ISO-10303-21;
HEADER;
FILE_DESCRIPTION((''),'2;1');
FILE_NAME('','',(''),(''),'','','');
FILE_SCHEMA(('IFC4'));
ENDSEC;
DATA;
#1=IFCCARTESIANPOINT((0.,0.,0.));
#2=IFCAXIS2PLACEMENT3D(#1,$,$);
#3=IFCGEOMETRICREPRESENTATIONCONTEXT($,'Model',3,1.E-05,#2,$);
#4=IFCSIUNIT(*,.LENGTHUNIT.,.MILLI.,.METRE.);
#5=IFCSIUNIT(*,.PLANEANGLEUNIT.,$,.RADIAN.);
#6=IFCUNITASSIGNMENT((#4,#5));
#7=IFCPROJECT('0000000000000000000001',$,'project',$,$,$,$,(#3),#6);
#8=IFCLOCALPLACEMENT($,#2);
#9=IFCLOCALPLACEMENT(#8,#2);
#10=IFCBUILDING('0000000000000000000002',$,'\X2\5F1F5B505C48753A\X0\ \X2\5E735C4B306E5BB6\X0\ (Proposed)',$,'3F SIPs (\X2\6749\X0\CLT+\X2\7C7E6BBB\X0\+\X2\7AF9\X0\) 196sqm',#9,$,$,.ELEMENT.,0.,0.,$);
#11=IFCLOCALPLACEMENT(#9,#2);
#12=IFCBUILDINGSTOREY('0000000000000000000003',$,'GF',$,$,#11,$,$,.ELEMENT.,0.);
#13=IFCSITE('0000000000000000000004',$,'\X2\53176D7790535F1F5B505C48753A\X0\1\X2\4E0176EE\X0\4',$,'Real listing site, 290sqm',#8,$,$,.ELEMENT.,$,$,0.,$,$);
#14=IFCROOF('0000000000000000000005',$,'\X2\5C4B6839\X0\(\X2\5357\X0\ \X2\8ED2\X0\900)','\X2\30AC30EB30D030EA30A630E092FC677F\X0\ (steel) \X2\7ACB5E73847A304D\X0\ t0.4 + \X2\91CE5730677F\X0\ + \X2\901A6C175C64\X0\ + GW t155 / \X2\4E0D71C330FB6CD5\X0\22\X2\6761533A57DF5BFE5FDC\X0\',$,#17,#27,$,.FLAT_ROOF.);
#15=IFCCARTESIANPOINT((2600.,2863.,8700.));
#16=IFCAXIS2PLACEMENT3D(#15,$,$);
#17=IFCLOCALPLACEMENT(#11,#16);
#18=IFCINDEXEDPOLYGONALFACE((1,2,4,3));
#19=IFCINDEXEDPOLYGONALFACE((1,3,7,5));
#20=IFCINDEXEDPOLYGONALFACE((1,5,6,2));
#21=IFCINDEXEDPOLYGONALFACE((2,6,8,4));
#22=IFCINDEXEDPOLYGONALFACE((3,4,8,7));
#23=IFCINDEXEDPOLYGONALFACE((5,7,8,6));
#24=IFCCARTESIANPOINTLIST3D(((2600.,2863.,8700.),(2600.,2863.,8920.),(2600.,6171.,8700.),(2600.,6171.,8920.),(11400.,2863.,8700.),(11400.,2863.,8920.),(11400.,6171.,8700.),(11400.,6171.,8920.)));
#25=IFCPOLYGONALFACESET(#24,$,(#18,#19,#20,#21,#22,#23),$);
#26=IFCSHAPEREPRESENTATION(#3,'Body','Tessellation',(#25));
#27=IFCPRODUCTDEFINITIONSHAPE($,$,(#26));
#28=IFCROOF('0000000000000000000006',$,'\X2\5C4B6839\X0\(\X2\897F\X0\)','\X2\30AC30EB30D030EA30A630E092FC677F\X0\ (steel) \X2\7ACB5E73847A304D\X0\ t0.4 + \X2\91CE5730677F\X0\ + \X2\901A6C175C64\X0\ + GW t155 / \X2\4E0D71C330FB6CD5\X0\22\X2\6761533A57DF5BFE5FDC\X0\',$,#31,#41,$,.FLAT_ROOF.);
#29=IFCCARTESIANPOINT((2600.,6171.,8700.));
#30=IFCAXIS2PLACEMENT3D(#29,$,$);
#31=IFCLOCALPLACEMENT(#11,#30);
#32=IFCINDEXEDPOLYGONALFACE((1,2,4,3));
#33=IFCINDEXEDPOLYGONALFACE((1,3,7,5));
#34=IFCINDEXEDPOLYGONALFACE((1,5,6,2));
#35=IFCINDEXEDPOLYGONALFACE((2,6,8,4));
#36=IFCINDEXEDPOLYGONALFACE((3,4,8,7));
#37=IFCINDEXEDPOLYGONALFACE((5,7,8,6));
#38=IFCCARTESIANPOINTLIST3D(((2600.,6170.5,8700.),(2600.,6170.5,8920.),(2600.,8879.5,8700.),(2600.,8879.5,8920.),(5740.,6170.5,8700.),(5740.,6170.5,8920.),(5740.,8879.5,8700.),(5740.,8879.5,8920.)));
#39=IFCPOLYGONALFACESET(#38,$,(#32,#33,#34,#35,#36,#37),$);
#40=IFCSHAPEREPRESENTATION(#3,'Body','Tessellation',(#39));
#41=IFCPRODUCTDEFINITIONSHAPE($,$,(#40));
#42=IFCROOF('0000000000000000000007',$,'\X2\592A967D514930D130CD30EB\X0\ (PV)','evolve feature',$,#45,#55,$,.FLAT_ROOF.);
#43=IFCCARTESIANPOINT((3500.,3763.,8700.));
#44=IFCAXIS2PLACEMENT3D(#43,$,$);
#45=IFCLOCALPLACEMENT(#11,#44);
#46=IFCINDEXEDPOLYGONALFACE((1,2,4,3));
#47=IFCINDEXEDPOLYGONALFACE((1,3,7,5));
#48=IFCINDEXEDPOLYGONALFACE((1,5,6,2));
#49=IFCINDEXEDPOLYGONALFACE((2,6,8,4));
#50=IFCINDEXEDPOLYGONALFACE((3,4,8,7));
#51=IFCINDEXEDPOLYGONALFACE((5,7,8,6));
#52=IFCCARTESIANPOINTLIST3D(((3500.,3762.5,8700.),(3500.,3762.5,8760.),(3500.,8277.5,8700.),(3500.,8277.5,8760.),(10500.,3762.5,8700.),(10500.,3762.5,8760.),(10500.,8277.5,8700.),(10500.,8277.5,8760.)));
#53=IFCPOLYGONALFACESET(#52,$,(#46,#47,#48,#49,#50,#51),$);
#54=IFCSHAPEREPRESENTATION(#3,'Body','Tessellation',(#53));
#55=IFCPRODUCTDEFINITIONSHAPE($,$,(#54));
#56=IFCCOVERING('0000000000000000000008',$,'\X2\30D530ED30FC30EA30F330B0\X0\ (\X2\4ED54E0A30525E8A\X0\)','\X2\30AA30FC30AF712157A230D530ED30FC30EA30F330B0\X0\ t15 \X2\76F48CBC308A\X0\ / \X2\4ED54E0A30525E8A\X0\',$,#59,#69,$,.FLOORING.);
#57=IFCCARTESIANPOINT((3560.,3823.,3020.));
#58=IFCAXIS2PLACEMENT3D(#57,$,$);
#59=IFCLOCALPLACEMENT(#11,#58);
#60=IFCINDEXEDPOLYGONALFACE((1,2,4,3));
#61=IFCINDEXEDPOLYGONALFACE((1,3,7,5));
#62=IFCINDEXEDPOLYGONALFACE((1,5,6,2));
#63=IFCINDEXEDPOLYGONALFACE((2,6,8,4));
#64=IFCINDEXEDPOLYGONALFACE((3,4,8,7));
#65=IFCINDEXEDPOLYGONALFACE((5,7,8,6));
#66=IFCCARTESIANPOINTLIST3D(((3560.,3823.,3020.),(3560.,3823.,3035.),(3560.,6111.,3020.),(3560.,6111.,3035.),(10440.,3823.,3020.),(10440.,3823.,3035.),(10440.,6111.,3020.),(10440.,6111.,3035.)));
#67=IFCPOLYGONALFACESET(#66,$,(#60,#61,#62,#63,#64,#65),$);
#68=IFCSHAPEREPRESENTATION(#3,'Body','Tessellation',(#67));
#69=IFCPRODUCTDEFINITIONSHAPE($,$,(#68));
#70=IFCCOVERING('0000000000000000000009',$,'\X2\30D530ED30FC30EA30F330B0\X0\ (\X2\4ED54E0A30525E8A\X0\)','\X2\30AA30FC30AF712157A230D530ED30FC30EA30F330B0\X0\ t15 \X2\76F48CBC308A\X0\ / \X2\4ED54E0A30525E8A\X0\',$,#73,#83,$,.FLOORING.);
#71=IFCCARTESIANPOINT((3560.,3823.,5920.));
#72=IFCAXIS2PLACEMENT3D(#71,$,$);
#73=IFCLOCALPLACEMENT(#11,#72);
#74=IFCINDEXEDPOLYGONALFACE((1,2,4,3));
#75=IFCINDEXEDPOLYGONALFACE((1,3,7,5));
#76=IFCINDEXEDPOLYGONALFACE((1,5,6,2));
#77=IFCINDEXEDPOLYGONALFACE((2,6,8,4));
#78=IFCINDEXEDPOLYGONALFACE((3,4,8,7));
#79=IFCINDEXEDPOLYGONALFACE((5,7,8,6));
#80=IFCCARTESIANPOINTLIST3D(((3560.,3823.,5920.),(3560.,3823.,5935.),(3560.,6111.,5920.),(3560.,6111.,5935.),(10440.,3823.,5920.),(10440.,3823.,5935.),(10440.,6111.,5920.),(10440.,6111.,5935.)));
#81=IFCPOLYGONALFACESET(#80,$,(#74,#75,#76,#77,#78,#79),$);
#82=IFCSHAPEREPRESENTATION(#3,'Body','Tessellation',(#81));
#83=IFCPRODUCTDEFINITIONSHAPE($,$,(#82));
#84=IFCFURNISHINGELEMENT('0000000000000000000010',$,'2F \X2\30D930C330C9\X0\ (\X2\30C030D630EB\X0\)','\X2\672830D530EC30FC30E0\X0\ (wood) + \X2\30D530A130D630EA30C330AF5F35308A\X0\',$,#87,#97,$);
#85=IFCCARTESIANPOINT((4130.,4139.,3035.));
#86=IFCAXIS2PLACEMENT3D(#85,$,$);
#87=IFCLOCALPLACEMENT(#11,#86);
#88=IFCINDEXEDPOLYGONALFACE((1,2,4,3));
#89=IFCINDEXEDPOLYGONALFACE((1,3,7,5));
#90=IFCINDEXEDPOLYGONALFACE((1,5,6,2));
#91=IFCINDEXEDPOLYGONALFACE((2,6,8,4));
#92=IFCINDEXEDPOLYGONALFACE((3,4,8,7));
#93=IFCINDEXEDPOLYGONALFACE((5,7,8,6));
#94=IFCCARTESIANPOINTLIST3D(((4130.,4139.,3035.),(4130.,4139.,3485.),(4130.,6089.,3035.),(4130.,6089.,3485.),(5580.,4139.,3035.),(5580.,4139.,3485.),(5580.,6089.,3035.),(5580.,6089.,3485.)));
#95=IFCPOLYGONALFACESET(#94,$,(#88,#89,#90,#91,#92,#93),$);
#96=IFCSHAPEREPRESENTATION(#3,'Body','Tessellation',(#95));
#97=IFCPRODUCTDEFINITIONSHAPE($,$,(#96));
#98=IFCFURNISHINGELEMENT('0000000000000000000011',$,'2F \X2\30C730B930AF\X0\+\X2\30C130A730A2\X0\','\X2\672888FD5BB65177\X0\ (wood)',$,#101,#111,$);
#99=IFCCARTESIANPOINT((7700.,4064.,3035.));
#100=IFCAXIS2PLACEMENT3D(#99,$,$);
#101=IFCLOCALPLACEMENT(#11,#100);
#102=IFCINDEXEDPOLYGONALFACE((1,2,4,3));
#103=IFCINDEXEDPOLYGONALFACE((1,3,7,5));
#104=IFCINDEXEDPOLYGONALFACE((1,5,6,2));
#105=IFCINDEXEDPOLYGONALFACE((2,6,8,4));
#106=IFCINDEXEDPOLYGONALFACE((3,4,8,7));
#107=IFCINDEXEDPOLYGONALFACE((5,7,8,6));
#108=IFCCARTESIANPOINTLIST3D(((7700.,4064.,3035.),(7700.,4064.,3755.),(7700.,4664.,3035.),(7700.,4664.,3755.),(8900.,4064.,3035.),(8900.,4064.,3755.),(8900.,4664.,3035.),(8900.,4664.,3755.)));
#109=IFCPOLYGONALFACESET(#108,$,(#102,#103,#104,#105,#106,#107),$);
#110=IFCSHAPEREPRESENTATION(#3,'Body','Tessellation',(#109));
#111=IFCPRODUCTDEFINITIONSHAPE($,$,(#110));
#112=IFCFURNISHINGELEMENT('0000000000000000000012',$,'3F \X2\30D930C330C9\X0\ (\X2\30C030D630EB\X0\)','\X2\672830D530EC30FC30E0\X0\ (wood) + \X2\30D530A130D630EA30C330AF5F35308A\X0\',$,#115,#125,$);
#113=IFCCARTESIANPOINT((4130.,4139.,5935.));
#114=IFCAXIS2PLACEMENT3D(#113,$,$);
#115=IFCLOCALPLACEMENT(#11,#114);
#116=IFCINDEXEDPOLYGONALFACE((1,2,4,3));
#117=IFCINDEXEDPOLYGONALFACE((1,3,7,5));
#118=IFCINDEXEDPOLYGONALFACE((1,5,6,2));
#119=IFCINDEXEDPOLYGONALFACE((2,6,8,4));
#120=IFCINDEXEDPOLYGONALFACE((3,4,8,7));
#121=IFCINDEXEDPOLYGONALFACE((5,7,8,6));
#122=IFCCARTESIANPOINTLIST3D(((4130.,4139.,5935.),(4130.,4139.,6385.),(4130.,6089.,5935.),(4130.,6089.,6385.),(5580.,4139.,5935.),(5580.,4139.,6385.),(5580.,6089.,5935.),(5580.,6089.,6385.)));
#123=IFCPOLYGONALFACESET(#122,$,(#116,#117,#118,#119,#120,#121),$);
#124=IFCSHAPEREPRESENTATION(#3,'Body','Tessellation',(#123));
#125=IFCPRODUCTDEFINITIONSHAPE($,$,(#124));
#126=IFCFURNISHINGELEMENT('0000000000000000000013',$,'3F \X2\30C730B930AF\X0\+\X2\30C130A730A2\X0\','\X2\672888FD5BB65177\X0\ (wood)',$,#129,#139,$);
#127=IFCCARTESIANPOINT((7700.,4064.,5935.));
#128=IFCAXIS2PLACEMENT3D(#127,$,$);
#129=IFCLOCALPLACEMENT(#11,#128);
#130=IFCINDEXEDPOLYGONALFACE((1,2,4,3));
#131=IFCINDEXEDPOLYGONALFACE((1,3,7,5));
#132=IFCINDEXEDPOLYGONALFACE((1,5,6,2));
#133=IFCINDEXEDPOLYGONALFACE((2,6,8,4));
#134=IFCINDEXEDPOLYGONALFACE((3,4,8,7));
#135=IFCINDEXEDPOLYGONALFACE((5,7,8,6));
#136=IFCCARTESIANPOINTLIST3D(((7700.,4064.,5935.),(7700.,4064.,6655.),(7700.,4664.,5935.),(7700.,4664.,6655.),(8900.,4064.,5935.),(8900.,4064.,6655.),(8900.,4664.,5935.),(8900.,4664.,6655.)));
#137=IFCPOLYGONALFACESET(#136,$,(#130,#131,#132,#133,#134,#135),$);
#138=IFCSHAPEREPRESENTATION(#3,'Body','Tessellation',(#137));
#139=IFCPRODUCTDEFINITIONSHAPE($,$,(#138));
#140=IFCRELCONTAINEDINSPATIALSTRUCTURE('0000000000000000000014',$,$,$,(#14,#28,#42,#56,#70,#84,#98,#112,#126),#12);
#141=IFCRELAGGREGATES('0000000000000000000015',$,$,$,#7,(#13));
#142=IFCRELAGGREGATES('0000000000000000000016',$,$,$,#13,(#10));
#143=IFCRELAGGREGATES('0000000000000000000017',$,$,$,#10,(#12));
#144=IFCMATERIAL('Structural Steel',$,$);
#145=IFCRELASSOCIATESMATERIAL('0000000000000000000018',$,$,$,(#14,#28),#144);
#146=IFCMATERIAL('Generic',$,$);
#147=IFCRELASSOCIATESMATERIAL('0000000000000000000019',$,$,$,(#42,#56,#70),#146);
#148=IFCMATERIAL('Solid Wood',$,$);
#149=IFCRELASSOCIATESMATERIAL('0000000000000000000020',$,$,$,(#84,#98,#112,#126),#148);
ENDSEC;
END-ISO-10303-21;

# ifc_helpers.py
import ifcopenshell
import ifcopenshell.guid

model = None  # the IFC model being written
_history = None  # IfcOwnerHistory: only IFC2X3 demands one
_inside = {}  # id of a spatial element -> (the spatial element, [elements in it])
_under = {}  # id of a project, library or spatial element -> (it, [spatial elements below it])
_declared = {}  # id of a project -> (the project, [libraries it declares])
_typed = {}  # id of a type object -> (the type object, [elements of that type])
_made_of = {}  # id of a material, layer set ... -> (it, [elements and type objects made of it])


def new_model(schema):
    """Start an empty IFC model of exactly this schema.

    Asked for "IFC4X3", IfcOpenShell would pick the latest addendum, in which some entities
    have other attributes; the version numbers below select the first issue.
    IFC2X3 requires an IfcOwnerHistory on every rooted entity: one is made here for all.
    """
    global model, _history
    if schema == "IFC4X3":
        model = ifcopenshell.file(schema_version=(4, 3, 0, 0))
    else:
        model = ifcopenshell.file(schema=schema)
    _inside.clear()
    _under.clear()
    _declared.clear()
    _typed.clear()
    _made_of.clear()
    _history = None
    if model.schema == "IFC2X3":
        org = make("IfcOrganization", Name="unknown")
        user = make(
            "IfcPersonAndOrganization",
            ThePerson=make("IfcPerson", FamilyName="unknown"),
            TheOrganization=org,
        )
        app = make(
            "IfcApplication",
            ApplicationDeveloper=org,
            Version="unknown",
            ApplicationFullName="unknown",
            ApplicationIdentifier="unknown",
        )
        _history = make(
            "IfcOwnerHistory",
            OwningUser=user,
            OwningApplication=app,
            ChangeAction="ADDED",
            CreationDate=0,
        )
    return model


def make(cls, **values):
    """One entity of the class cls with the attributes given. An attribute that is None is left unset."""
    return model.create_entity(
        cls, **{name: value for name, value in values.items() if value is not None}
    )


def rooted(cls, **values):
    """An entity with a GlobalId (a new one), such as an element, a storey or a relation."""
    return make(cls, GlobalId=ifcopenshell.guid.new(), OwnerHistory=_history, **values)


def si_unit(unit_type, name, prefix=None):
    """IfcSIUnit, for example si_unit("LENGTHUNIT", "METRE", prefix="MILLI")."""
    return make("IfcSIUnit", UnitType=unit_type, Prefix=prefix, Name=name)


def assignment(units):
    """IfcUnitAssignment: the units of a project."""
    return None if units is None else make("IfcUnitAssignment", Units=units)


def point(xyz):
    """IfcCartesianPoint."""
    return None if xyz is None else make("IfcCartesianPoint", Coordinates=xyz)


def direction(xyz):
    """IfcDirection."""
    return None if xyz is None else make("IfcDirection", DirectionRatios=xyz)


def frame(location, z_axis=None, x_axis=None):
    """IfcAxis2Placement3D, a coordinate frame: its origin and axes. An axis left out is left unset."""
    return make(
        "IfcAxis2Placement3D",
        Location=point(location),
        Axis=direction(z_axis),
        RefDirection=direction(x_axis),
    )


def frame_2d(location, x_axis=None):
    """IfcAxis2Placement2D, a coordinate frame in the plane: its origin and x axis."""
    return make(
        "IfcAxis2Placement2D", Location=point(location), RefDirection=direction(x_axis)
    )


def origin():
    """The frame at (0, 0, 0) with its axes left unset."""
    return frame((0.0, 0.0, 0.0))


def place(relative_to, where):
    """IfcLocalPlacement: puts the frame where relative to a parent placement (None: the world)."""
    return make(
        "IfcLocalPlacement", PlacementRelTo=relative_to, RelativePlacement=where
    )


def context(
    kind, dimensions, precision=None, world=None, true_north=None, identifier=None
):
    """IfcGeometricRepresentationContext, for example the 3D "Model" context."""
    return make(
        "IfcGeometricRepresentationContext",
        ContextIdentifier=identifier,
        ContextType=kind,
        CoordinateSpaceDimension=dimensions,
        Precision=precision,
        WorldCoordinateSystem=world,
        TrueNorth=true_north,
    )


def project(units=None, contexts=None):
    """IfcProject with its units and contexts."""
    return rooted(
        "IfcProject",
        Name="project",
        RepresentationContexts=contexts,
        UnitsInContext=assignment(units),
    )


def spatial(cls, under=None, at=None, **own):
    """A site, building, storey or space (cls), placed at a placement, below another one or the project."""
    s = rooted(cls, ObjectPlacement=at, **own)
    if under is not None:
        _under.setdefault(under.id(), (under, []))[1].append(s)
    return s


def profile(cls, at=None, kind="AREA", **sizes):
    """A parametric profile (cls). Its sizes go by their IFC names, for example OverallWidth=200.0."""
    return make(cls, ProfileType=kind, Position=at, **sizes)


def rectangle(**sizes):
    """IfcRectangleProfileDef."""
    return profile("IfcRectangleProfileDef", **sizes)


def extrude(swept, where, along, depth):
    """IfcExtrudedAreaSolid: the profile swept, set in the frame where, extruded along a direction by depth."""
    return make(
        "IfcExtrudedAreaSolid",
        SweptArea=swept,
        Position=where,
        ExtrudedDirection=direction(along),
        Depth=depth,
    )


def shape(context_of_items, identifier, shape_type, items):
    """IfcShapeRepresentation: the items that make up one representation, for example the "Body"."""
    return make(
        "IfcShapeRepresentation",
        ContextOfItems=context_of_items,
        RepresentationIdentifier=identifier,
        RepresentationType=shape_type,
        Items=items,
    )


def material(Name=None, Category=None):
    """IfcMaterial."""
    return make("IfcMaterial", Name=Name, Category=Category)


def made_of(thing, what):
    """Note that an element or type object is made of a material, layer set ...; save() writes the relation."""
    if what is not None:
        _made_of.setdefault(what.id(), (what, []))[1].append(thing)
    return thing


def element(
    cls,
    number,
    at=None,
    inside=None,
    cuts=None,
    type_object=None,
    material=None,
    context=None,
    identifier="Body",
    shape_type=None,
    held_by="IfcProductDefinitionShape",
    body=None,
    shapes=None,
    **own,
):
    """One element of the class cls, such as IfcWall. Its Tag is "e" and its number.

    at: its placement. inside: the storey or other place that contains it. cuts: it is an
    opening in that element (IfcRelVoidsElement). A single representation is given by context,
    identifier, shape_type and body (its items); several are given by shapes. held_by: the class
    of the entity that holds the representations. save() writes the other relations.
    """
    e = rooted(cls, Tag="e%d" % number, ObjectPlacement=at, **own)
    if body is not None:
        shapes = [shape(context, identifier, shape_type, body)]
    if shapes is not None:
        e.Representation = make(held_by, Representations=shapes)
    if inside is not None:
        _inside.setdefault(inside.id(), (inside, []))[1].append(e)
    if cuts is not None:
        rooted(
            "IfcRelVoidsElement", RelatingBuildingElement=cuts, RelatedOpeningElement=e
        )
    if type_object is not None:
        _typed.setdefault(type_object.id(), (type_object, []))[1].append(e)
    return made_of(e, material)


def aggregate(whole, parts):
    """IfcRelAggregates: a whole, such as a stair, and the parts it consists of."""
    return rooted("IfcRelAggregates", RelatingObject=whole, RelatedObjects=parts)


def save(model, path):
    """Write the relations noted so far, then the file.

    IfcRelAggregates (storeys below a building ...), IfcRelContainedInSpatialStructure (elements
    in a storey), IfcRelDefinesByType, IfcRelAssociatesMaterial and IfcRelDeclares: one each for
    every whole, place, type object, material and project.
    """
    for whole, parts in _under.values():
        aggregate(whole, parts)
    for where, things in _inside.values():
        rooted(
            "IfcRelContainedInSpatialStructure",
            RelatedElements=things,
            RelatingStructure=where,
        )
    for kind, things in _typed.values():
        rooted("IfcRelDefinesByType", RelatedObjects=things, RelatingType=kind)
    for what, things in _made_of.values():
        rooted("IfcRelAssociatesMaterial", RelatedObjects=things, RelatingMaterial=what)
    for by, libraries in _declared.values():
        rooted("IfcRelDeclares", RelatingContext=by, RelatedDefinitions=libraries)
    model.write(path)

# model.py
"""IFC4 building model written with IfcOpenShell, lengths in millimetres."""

from ifc_helpers import new_model, si_unit, frame, frame_2d, origin, place, context, project, spatial, rectangle, extrude, material, element, save


model = new_model("IFC4")

# Units and contexts
model_context = context("Model", 3, precision=1e-05, world=origin())
ifc_project = project(units=[si_unit("LENGTHUNIT", "METRE", prefix="MILLI"), si_unit("PLANEANGLEUNIT", "RADIAN")], contexts=[model_context])

# Site, building, storey
site_placement = place(None, origin())
site = spatial("IfcSite", under=ifc_project, at=site_placement, Name="北海道弟子屈町1丁目4", ObjectType="Real listing site, 290sqm", CompositionType="ELEMENT", RefElevation=0.0)
building_placement = place(site_placement, origin())
building = spatial("IfcBuilding", under=site, at=building_placement, Name="弟子屈町 平屋の家 (Proposed)", ObjectType="3F SIPs (杉CLT+籾殻+竹) 196sqm", CompositionType="ELEMENT", ElevationOfRefHeight=0.0, ElevationOfTerrain=0.0)
storey_placement = place(building_placement, origin())
storey = spatial("IfcBuildingStorey", under=building, at=storey_placement, Name="GF", CompositionType="ELEMENT", Elevation=0.0)

# Shared definitions
ifc_material_1 = material(Name="Solid Wood")

# Roofs
ifc_material_2 = material(Name="Structural Steel")
roof_1_placement = place(storey_placement, frame((2600.0, 2863.0, 8700.0)))
element("IfcRoof", 1, at=roof_1_placement, inside=storey, material=ifc_material_2, Name="屋根(南 軒900)", Description="ガルバリウム鋼板 (steel) 立平葺き t0.4 + 野地板 + 通気層 + GW t155 / 不燃・法22条区域対応", PredefinedType="FLAT_ROOF", context=model_context, shape_type="SweptSolid", body=[
    extrude(rectangle(XDim=8800.0, YDim=3308.0, at=frame_2d((4400.0, 1654.0))), frame((2600.0, 2863.0, 8700.0)), (0.0, 0.0, 1.0), 220.0),
])
roof_2_placement = place(storey_placement, frame((2600.0, 6171.0, 8700.0)))
element("IfcRoof", 2, at=roof_2_placement, inside=storey, material=ifc_material_2, Name="屋根(西)", Description="ガルバリウム鋼板 (steel) 立平葺き t0.4 + 野地板 + 通気層 + GW t155 / 不燃・法22条区域対応", PredefinedType="FLAT_ROOF", context=model_context, shape_type="SweptSolid", body=[
    extrude(rectangle(XDim=3140.0, YDim=2709.0, at=frame_2d((1570.0, 1354.0))), frame((2600.0, 6171.0, 8700.0)), (0.0, 0.0, 1.0), 220.0),
])
ifc_material_3 = material(Name="Generic")
roof_3_placement = place(storey_placement, frame((3500.0, 3763.0, 8700.0)))
element("IfcRoof", 3, at=roof_3_placement, inside=storey, material=ifc_material_3, Name="太陽光パネル (PV)", Description="evolve feature", PredefinedType="FLAT_ROOF", context=model_context, shape_type="SweptSolid", body=[
    extrude(rectangle(XDim=7000.0, YDim=4515.0, at=frame_2d((3500.0, 2257.0))), frame((3500.0, 3763.0, 8700.0)), (0.0, 0.0, 1.0), 60.0),
])

# Coverings
covering_1_placement = place(storey_placement, frame((3560.0, 3823.0, 3020.0)))
element("IfcCovering", 4, at=covering_1_placement, inside=storey, material=ifc_material_3, Name="フローリング (仕上げ床)", Description="オーク無垢フローリング t15 直貼り / 仕上げ床", PredefinedType="FLOORING", context=model_context, shape_type="SweptSolid", body=[
    extrude(rectangle(XDim=6880.0, YDim=2288.0, at=frame_2d((3440.0, 1144.0))), frame((3560.0, 3823.0, 3020.0)), (0.0, 0.0, 1.0), 15.0),
])
covering_2_placement = place(storey_placement, frame((3560.0, 3823.0, 5920.0)))
element("IfcCovering", 5, at=covering_2_placement, inside=storey, material=ifc_material_3, Name="フローリング (仕上げ床)", Description="オーク無垢フローリング t15 直貼り / 仕上げ床", PredefinedType="FLOORING", context=model_context, shape_type="SweptSolid", body=[
    extrude(rectangle(XDim=6880.0, YDim=2288.0, at=frame_2d((3440.0, 1144.0))), frame((3560.0, 3823.0, 5920.0)), (0.0, 0.0, 1.0), 15.0),
])

# Furnishing elements
furnishing_1_placement = place(storey_placement, frame((4130.0, 4139.0, 3035.0)))
element("IfcFurnishingElement", 6, at=furnishing_1_placement, inside=storey, material=ifc_material_1, Name="2F ベッド (ダブル)", Description="木フレーム (wood) + ファブリック張り", context=model_context, shape_type="SweptSolid", body=[
    extrude(rectangle(XDim=1450.0, YDim=1950.0, at=frame_2d((725.0, 975.0))), frame((4130.0, 4139.0, 3035.0)), (0.0, 0.0, 1.0), 450.0),
])
furnishing_2_placement = place(storey_placement, frame((7700.0, 4064.0, 3035.0)))
element("IfcFurnishingElement", 7, at=furnishing_2_placement, inside=storey, material=ifc_material_1, Name="2F デスク+チェア", Description="木製家具 (wood)", context=model_context, shape_type="SweptSolid", body=[
    extrude(rectangle(XDim=1200.0, YDim=600.0, at=frame_2d((600.0, 300.0))), frame((7700.0, 4064.0, 3035.0)), (0.0, 0.0, 1.0), 720.0),
])
furnishing_3_placement = place(storey_placement, frame((4130.0, 4139.0, 5935.0)))
element("IfcFurnishingElement", 8, at=furnishing_3_placement, inside=storey, material=ifc_material_1, Name="3F ベッド (ダブル)", Description="木フレーム (wood) + ファブリック張り", context=model_context, shape_type="SweptSolid", body=[
    extrude(rectangle(XDim=1450.0, YDim=1950.0, at=frame_2d((725.0, 975.0))), frame((4130.0, 4139.0, 5935.0)), (0.0, 0.0, 1.0), 450.0),
])
furnishing_4_placement = place(storey_placement, frame((7700.0, 4064.0, 5935.0)))
element("IfcFurnishingElement", 9, at=furnishing_4_placement, inside=storey, material=ifc_material_1, Name="3F デスク+チェア", Description="木製家具 (wood)", context=model_context, shape_type="SweptSolid", body=[
    extrude(rectangle(XDim=1200.0, YDim=600.0, at=frame_2d((600.0, 300.0))), frame((7700.0, 4064.0, 5935.0)), (0.0, 0.0, 1.0), 720.0),
])

save(model, "model.ifc")
